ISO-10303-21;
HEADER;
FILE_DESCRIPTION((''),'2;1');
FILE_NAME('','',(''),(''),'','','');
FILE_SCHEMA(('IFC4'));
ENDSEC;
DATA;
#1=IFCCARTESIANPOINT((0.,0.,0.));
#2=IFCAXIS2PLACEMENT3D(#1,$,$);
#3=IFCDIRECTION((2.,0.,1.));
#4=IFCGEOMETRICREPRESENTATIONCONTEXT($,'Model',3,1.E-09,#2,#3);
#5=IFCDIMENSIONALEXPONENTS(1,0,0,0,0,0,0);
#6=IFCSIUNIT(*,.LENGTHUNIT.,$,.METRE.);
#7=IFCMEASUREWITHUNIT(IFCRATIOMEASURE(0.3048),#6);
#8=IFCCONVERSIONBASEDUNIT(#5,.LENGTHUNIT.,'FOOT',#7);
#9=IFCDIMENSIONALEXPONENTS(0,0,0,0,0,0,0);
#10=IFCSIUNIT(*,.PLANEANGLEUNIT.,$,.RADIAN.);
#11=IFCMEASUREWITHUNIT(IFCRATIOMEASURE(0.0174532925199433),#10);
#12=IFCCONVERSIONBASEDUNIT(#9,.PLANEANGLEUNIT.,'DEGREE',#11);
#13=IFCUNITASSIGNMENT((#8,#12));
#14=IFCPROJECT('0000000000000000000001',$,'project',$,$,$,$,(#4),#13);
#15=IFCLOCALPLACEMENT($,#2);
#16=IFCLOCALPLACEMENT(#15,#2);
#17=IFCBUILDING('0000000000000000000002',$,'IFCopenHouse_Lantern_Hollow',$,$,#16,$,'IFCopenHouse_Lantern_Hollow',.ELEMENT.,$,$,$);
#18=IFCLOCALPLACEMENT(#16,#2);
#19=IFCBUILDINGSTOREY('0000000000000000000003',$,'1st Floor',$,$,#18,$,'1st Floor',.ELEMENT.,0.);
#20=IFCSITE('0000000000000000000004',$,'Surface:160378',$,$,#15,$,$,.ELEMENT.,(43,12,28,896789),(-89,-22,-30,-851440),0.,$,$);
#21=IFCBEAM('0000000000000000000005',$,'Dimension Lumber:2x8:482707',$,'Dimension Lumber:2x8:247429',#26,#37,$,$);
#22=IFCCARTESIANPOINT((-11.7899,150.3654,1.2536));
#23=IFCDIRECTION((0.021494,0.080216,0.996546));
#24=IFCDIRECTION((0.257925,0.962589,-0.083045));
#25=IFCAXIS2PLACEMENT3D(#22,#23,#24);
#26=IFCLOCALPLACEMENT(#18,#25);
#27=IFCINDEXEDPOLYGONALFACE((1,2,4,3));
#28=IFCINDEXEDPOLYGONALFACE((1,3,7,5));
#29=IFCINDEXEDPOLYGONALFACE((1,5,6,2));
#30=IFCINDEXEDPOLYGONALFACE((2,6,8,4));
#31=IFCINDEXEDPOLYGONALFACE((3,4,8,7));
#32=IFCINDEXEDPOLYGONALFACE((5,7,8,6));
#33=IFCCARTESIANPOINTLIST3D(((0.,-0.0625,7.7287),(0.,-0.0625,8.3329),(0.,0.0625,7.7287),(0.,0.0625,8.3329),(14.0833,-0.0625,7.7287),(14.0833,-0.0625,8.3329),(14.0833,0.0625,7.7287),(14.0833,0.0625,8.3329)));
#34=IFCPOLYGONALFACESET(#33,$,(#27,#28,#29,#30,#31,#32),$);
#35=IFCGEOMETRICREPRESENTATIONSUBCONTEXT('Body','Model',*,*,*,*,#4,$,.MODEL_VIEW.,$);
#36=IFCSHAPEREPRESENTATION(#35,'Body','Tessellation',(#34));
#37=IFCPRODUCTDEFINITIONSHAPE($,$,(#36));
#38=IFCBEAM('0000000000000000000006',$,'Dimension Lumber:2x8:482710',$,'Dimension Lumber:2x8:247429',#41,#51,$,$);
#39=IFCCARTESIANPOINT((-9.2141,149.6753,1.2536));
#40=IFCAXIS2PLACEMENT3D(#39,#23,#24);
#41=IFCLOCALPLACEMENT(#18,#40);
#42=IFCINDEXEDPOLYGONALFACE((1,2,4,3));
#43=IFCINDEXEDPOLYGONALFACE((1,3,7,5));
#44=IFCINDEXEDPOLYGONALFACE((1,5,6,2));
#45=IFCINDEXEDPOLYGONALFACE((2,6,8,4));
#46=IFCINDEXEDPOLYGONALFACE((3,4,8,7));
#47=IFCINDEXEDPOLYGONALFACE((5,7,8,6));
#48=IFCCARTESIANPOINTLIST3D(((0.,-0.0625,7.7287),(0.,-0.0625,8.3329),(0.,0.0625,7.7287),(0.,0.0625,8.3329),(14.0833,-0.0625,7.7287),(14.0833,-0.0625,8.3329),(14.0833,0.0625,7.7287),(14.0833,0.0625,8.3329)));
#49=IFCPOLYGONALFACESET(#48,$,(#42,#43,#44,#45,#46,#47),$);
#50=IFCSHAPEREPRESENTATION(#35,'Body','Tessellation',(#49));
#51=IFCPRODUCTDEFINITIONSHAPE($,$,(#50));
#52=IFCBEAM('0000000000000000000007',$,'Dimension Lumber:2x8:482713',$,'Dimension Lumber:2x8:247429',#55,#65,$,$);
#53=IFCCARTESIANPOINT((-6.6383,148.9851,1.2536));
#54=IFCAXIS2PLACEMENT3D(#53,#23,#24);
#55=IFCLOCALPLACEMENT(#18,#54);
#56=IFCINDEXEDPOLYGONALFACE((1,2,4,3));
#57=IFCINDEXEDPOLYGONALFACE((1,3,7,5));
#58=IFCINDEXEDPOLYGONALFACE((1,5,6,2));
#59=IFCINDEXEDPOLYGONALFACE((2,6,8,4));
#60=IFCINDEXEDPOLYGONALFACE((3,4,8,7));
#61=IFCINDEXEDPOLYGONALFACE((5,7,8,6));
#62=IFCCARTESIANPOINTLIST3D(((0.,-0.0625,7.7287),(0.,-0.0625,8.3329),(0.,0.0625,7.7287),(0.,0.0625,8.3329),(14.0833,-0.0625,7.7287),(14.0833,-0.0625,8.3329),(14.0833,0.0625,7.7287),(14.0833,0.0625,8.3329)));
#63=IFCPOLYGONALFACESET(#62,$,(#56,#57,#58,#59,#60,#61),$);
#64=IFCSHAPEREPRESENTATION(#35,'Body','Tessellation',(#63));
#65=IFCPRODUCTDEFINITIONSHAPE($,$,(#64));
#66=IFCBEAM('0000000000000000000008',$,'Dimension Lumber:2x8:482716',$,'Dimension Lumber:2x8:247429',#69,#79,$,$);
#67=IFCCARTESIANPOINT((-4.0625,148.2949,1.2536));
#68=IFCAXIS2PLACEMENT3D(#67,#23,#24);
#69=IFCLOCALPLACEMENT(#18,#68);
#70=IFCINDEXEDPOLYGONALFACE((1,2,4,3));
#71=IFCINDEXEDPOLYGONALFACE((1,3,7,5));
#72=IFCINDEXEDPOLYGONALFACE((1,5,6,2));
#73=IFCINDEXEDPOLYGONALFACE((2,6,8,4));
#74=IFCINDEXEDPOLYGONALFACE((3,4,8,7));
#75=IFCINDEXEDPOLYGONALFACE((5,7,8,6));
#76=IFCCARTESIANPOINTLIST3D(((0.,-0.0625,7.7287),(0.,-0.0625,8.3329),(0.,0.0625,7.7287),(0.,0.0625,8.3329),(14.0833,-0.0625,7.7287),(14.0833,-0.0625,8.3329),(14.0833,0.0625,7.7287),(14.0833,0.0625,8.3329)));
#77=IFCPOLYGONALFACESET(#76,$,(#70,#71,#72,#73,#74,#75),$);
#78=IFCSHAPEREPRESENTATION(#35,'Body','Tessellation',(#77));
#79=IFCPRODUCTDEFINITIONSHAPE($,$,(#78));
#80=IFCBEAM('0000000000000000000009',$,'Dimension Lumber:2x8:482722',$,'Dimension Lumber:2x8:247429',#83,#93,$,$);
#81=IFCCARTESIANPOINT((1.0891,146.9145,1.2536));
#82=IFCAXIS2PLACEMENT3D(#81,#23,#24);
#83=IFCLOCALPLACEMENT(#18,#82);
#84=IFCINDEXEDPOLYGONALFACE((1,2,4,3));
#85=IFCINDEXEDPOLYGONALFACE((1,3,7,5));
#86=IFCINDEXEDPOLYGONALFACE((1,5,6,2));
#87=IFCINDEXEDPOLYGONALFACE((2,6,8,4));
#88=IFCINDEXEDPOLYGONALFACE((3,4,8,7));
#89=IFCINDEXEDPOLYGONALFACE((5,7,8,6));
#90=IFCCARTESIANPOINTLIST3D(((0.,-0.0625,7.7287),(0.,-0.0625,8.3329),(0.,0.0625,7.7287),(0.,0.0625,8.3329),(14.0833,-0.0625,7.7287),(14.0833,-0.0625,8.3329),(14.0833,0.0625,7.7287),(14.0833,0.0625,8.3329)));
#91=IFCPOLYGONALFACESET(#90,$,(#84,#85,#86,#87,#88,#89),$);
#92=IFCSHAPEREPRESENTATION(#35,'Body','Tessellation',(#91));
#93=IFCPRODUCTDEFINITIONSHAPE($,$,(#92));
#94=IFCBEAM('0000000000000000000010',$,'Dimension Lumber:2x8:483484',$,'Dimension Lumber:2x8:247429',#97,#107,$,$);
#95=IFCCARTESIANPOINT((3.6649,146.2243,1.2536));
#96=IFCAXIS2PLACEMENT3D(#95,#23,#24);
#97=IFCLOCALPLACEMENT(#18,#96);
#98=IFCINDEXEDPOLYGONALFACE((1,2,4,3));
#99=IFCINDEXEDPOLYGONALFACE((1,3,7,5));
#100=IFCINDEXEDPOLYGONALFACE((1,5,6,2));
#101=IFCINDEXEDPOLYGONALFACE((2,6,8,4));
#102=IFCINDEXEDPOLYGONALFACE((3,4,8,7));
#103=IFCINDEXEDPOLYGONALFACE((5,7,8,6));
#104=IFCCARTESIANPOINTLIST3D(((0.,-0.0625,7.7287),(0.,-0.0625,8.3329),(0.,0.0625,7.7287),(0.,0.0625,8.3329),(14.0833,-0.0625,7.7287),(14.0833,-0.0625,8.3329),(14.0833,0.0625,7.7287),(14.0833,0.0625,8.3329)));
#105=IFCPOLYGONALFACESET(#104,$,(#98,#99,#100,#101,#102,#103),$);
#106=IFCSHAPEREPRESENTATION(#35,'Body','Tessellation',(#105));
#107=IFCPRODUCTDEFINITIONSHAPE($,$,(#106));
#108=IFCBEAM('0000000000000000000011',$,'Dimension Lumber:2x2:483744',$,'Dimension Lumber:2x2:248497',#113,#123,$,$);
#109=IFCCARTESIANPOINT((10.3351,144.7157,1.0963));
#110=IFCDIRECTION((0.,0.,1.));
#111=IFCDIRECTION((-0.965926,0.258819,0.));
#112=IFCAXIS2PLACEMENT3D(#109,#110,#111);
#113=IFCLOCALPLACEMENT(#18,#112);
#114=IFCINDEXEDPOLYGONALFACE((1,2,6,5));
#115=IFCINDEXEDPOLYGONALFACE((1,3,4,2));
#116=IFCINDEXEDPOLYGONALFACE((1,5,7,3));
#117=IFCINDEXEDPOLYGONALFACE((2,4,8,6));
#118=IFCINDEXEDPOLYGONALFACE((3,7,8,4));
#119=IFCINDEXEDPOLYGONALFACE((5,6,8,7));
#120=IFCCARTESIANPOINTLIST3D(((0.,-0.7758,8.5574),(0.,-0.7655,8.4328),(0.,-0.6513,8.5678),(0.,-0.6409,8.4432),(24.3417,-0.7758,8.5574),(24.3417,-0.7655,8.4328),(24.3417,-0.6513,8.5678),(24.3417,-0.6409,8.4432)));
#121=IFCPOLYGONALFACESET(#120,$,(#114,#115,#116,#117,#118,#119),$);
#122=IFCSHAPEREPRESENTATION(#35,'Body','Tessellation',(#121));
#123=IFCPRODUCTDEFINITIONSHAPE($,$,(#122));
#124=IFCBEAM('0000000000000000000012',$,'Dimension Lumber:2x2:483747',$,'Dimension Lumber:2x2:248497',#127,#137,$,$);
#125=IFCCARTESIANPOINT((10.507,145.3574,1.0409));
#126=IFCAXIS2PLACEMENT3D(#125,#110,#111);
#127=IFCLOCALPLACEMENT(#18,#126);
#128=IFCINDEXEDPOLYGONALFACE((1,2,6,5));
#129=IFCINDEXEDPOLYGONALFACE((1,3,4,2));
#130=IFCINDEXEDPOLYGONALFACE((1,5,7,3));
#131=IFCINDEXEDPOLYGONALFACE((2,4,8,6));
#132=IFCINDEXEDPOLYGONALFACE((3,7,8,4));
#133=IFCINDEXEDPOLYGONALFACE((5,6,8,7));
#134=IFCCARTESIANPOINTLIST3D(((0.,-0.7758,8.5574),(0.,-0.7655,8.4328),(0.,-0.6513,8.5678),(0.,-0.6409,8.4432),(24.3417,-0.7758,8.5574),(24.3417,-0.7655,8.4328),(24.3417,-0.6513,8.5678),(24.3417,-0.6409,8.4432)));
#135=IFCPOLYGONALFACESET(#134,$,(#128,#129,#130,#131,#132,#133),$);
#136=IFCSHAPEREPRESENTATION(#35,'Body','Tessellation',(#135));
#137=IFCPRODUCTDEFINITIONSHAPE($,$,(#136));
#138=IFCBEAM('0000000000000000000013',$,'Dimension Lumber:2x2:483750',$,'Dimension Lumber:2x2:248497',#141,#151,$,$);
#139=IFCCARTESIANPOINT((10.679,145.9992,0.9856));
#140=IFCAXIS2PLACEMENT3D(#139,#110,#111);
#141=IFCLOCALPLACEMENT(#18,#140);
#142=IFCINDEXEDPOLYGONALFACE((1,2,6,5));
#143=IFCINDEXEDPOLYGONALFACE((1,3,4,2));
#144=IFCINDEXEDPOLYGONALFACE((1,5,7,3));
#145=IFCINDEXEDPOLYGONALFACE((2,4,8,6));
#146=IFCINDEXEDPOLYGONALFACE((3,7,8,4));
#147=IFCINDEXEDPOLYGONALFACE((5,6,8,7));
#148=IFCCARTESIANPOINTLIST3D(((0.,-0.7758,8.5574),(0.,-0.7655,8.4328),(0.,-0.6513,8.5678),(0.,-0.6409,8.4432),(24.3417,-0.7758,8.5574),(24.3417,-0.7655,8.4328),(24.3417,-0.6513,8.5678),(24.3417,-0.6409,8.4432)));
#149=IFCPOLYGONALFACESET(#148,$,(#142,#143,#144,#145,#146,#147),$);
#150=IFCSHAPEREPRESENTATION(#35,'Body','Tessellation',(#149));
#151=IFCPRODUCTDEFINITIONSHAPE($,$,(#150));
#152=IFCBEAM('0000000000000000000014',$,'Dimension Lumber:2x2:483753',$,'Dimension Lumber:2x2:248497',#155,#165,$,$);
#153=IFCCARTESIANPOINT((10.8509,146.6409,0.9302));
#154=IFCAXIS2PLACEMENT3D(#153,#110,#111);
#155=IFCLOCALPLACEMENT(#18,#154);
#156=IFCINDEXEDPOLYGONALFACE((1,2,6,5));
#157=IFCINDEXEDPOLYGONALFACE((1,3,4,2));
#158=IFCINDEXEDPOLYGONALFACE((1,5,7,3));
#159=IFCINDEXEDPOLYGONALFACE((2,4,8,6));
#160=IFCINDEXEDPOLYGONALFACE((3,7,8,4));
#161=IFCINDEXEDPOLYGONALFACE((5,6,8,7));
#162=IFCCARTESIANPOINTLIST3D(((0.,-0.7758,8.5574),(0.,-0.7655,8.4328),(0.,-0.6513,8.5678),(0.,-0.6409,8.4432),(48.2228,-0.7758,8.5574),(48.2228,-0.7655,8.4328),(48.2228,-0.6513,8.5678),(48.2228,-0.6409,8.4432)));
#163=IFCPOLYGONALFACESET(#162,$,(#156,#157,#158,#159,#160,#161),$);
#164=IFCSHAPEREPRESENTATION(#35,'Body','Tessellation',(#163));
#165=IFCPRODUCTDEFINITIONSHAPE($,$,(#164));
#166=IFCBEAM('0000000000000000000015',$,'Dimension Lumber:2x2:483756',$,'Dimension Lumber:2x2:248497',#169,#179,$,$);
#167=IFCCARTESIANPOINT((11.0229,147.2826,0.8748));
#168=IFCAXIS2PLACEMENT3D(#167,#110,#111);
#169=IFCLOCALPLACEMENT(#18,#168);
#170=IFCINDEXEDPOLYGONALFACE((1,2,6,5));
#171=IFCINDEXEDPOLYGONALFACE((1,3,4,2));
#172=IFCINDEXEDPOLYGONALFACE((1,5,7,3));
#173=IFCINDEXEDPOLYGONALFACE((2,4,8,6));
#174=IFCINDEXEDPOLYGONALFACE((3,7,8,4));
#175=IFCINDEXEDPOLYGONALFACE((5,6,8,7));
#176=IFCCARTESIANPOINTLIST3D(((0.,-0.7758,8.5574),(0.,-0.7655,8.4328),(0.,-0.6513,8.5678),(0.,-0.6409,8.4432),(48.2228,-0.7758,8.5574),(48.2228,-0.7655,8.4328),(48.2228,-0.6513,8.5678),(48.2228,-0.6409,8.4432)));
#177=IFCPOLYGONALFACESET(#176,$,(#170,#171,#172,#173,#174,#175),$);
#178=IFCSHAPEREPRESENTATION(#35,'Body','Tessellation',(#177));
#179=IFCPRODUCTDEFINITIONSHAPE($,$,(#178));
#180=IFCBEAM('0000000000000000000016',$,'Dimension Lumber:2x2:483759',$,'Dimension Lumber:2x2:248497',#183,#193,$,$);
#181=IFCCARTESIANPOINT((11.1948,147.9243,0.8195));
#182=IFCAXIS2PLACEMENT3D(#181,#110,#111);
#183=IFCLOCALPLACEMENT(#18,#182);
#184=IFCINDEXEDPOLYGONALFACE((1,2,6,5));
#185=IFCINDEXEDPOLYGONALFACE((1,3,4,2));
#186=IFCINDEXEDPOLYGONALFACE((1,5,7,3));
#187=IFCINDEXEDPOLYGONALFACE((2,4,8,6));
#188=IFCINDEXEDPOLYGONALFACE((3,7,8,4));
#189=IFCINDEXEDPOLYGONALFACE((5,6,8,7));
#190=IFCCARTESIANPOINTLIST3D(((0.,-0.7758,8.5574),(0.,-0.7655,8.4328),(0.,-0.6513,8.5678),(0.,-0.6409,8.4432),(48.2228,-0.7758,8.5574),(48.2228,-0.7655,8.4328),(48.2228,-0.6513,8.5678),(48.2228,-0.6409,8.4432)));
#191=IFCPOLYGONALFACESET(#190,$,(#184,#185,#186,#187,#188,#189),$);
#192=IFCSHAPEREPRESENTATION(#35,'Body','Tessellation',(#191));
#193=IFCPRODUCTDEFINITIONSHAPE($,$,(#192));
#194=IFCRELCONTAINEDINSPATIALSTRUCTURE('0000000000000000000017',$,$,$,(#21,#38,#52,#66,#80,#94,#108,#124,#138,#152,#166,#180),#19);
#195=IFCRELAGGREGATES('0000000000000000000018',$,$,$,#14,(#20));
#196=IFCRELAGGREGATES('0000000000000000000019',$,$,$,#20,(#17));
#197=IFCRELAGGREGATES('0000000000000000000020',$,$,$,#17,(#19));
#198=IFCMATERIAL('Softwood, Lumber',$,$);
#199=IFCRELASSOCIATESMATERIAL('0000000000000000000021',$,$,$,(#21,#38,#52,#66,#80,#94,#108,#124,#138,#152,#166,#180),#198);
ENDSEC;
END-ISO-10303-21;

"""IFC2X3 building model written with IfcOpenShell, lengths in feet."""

from ifc_helpers import new_model, entity, si_unit, converted_unit, direction, frame, frame_2d, origin, place, context, subcontext, project, spatial, rectangle, extrude, material, element, save


model = new_model("IFC2X3")

# Units and contexts
model_context = context("Model", 3, precision=1e-09, world=origin(), true_north=direction((2.0, 0.0, 1.0)))
body_context = subcontext(model_context, "Body", "Model", "MODEL_VIEW")
ifc_project = project(units=[converted_unit("LENGTHUNIT", "FOOT", entity("IfcRatioMeasure", 0.3048), si_unit("LENGTHUNIT", "METRE"), dimensions=[1, 0, 0, 0, 0, 0, 0]), converted_unit("PLANEANGLEUNIT", "DEGREE", entity("IfcRatioMeasure", 0.0174532925199433), si_unit("PLANEANGLEUNIT", "RADIAN"), dimensions=[0, 0, 0, 0, 0, 0, 0])], contexts=[model_context])

# Site, building, storey
site_placement = place(None, origin())
site = spatial("IfcSite", under=ifc_project, at=site_placement, Name="Surface:160378", CompositionType="ELEMENT", RefLatitude=(43, 12, 28, 896789), RefLongitude=(-89, -22, -30, -851440), RefElevation=0.0)
building_placement = place(site_placement, origin())
building = spatial("IfcBuilding", under=site, at=building_placement, Name="IFCopenHouse_Lantern_Hollow", LongName="IFCopenHouse_Lantern_Hollow", CompositionType="ELEMENT")
storey_placement = place(building_placement, origin())
storey = spatial("IfcBuildingStorey", under=building, at=storey_placement, Name="1st Floor", LongName="1st Floor", CompositionType="ELEMENT", Elevation=0.0)

# Beams
ifc_material = material(Name="Softwood, Lumber")
beam_1_placement = place(storey_placement, frame((-11.7899, 150.3654, 1.2536), z_axis=(0.021494, 0.080216, 0.996546), x_axis=(0.257925, 0.962589, -0.083045)))
element("IfcBeam", 1, at=beam_1_placement, inside=storey, material=ifc_material, Name="Dimension Lumber:2x8:482707", ObjectType="Dimension Lumber:2x8:247429", context=body_context, shape_type="SweptSolid", body=[
    extrude(rectangle(XDim=0.6042, YDim=0.125, at=frame_2d((0.0, 0.0), x_axis=(1.0, 0.0))), frame((0.0, 0.0, 8.0308), z_axis=(1.0, 0.0, 0.0), x_axis=(0.0, 0.0, -1.0)), (0.0, 0.0, 1.0), 14.0833),
])
beam_2_placement = place(storey_placement, frame((-9.2141, 149.6753, 1.2536), z_axis=(0.021494, 0.080216, 0.996546), x_axis=(0.257925, 0.962589, -0.083045)))
element("IfcBeam", 2, at=beam_2_placement, inside=storey, material=ifc_material, Name="Dimension Lumber:2x8:482710", ObjectType="Dimension Lumber:2x8:247429", context=body_context, shape_type="SweptSolid", body=[
    extrude(rectangle(XDim=0.6042, YDim=0.125, at=frame_2d((0.0, 0.0), x_axis=(1.0, 0.0))), frame((0.0, 0.0, 8.0308), z_axis=(1.0, 0.0, 0.0), x_axis=(0.0, 0.0, -1.0)), (0.0, 0.0, 1.0), 14.0833),
])
beam_3_placement = place(storey_placement, frame((-6.6383, 148.9851, 1.2536), z_axis=(0.021494, 0.080216, 0.996546), x_axis=(0.257925, 0.962589, -0.083045)))
element("IfcBeam", 3, at=beam_3_placement, inside=storey, material=ifc_material, Name="Dimension Lumber:2x8:482713", ObjectType="Dimension Lumber:2x8:247429", context=body_context, shape_type="SweptSolid", body=[
    extrude(rectangle(XDim=0.6042, YDim=0.125, at=frame_2d((0.0, 0.0), x_axis=(1.0, 0.0))), frame((0.0, 0.0, 8.0308), z_axis=(1.0, 0.0, 0.0), x_axis=(0.0, 0.0, -1.0)), (0.0, 0.0, 1.0), 14.0833),
])
beam_4_placement = place(storey_placement, frame((-4.0625, 148.2949, 1.2536), z_axis=(0.021494, 0.080216, 0.996546), x_axis=(0.257925, 0.962589, -0.083045)))
element("IfcBeam", 4, at=beam_4_placement, inside=storey, material=ifc_material, Name="Dimension Lumber:2x8:482716", ObjectType="Dimension Lumber:2x8:247429", context=body_context, shape_type="SweptSolid", body=[
    extrude(rectangle(XDim=0.6042, YDim=0.125, at=frame_2d((0.0, 0.0), x_axis=(1.0, 0.0))), frame((0.0, 0.0, 8.0308), z_axis=(1.0, 0.0, 0.0), x_axis=(0.0, 0.0, -1.0)), (0.0, 0.0, 1.0), 14.0833),
])
beam_5_placement = place(storey_placement, frame((1.0891, 146.9145, 1.2536), z_axis=(0.021494, 0.080216, 0.996546), x_axis=(0.257925, 0.962589, -0.083045)))
element("IfcBeam", 5, at=beam_5_placement, inside=storey, material=ifc_material, Name="Dimension Lumber:2x8:482722", ObjectType="Dimension Lumber:2x8:247429", context=body_context, shape_type="SweptSolid", body=[
    extrude(rectangle(XDim=0.6042, YDim=0.125, at=frame_2d((0.0, 0.0), x_axis=(1.0, 0.0))), frame((0.0, 0.0, 8.0308), z_axis=(1.0, 0.0, 0.0), x_axis=(0.0, 0.0, -1.0)), (0.0, 0.0, 1.0), 14.0833),
])
beam_6_placement = place(storey_placement, frame((3.6649, 146.2243, 1.2536), z_axis=(0.021494, 0.080216, 0.996546), x_axis=(0.257925, 0.962589, -0.083045)))
element("IfcBeam", 6, at=beam_6_placement, inside=storey, material=ifc_material, Name="Dimension Lumber:2x8:483484", ObjectType="Dimension Lumber:2x8:247429", context=body_context, shape_type="SweptSolid", body=[
    extrude(rectangle(XDim=0.6042, YDim=0.125, at=frame_2d((0.0, 0.0), x_axis=(1.0, 0.0))), frame((0.0, 0.0, 8.0308), z_axis=(1.0, 0.0, 0.0), x_axis=(0.0, 0.0, -1.0)), (0.0, 0.0, 1.0), 14.0833),
])
beam_7_placement = place(storey_placement, frame((10.3351, 144.7157, 1.0963), z_axis=(0.0, 0.0, 1.0), x_axis=(-0.965926, 0.258819, 0.0)))
element("IfcBeam", 7, at=beam_7_placement, inside=storey, material=ifc_material, Name="Dimension Lumber:2x2:483744", ObjectType="Dimension Lumber:2x2:248497", context=body_context, shape_type="SweptSolid", body=[
    extrude(rectangle(XDim=0.125, YDim=0.125, at=frame_2d((0.0, 0.0), x_axis=(0.0, 1.0))), frame((0.0, -0.7084, 8.5003), z_axis=(1.0, 0.0, 0.0), x_axis=(0.0, -0.996546, -0.083045)), (0.0, 0.0, 1.0), 24.3417),
])
beam_8_placement = place(storey_placement, frame((10.507, 145.3574, 1.0409), z_axis=(0.0, 0.0, 1.0), x_axis=(-0.965926, 0.258819, 0.0)))
element("IfcBeam", 8, at=beam_8_placement, inside=storey, material=ifc_material, Name="Dimension Lumber:2x2:483747", ObjectType="Dimension Lumber:2x2:248497", context=body_context, shape_type="SweptSolid", body=[
    extrude(rectangle(XDim=0.125, YDim=0.125, at=frame_2d((0.0, 0.0), x_axis=(0.0, 1.0))), frame((0.0, -0.7084, 8.5003), z_axis=(1.0, 0.0, 0.0), x_axis=(0.0, -0.996546, -0.083045)), (0.0, 0.0, 1.0), 24.3417),
])
beam_9_placement = place(storey_placement, frame((10.679, 145.9992, 0.9856), z_axis=(0.0, 0.0, 1.0), x_axis=(-0.965926, 0.258819, 0.0)))
element("IfcBeam", 9, at=beam_9_placement, inside=storey, material=ifc_material, Name="Dimension Lumber:2x2:483750", ObjectType="Dimension Lumber:2x2:248497", context=body_context, shape_type="SweptSolid", body=[
    extrude(rectangle(XDim=0.125, YDim=0.125, at=frame_2d((0.0, 0.0), x_axis=(0.0, 1.0))), frame((0.0, -0.7084, 8.5003), z_axis=(1.0, 0.0, 0.0), x_axis=(0.0, -0.996546, -0.083045)), (0.0, 0.0, 1.0), 24.3417),
])
beam_10_placement = place(storey_placement, frame((10.8509, 146.6409, 0.9302), z_axis=(0.0, 0.0, 1.0), x_axis=(-0.965926, 0.258819, 0.0)))
element("IfcBeam", 10, at=beam_10_placement, inside=storey, material=ifc_material, Name="Dimension Lumber:2x2:483753", ObjectType="Dimension Lumber:2x2:248497", context=body_context, shape_type="SweptSolid", body=[
    extrude(rectangle(XDim=0.125, YDim=0.125, at=frame_2d((0.0, 0.0), x_axis=(0.0, 1.0))), frame((0.0, -0.7084, 8.5003), z_axis=(1.0, 0.0, 0.0), x_axis=(0.0, -0.996546, -0.083045)), (0.0, 0.0, 1.0), 48.2228),
])
beam_11_placement = place(storey_placement, frame((11.0229, 147.2826, 0.8748), z_axis=(0.0, 0.0, 1.0), x_axis=(-0.965926, 0.258819, 0.0)))
element("IfcBeam", 11, at=beam_11_placement, inside=storey, material=ifc_material, Name="Dimension Lumber:2x2:483756", ObjectType="Dimension Lumber:2x2:248497", context=body_context, shape_type="SweptSolid", body=[
    extrude(rectangle(XDim=0.125, YDim=0.125, at=frame_2d((0.0, 0.0), x_axis=(0.0, 1.0))), frame((0.0, -0.7084, 8.5003), z_axis=(1.0, 0.0, 0.0), x_axis=(0.0, -0.996546, -0.083045)), (0.0, 0.0, 1.0), 48.2228),
])
beam_12_placement = place(storey_placement, frame((11.1948, 147.9243, 0.8195), z_axis=(0.0, 0.0, 1.0), x_axis=(-0.965926, 0.258819, 0.0)))
element("IfcBeam", 12, at=beam_12_placement, inside=storey, material=ifc_material, Name="Dimension Lumber:2x2:483759", ObjectType="Dimension Lumber:2x2:248497", context=body_context, shape_type="SweptSolid", body=[
    extrude(rectangle(XDim=0.125, YDim=0.125, at=frame_2d((0.0, 0.0), x_axis=(0.0, 1.0))), frame((0.0, -0.7084, 8.5003), z_axis=(1.0, 0.0, 0.0), x_axis=(0.0, -0.996546, -0.083045)), (0.0, 0.0, 1.0), 48.2228),
])

save(model, "model.ifc")
